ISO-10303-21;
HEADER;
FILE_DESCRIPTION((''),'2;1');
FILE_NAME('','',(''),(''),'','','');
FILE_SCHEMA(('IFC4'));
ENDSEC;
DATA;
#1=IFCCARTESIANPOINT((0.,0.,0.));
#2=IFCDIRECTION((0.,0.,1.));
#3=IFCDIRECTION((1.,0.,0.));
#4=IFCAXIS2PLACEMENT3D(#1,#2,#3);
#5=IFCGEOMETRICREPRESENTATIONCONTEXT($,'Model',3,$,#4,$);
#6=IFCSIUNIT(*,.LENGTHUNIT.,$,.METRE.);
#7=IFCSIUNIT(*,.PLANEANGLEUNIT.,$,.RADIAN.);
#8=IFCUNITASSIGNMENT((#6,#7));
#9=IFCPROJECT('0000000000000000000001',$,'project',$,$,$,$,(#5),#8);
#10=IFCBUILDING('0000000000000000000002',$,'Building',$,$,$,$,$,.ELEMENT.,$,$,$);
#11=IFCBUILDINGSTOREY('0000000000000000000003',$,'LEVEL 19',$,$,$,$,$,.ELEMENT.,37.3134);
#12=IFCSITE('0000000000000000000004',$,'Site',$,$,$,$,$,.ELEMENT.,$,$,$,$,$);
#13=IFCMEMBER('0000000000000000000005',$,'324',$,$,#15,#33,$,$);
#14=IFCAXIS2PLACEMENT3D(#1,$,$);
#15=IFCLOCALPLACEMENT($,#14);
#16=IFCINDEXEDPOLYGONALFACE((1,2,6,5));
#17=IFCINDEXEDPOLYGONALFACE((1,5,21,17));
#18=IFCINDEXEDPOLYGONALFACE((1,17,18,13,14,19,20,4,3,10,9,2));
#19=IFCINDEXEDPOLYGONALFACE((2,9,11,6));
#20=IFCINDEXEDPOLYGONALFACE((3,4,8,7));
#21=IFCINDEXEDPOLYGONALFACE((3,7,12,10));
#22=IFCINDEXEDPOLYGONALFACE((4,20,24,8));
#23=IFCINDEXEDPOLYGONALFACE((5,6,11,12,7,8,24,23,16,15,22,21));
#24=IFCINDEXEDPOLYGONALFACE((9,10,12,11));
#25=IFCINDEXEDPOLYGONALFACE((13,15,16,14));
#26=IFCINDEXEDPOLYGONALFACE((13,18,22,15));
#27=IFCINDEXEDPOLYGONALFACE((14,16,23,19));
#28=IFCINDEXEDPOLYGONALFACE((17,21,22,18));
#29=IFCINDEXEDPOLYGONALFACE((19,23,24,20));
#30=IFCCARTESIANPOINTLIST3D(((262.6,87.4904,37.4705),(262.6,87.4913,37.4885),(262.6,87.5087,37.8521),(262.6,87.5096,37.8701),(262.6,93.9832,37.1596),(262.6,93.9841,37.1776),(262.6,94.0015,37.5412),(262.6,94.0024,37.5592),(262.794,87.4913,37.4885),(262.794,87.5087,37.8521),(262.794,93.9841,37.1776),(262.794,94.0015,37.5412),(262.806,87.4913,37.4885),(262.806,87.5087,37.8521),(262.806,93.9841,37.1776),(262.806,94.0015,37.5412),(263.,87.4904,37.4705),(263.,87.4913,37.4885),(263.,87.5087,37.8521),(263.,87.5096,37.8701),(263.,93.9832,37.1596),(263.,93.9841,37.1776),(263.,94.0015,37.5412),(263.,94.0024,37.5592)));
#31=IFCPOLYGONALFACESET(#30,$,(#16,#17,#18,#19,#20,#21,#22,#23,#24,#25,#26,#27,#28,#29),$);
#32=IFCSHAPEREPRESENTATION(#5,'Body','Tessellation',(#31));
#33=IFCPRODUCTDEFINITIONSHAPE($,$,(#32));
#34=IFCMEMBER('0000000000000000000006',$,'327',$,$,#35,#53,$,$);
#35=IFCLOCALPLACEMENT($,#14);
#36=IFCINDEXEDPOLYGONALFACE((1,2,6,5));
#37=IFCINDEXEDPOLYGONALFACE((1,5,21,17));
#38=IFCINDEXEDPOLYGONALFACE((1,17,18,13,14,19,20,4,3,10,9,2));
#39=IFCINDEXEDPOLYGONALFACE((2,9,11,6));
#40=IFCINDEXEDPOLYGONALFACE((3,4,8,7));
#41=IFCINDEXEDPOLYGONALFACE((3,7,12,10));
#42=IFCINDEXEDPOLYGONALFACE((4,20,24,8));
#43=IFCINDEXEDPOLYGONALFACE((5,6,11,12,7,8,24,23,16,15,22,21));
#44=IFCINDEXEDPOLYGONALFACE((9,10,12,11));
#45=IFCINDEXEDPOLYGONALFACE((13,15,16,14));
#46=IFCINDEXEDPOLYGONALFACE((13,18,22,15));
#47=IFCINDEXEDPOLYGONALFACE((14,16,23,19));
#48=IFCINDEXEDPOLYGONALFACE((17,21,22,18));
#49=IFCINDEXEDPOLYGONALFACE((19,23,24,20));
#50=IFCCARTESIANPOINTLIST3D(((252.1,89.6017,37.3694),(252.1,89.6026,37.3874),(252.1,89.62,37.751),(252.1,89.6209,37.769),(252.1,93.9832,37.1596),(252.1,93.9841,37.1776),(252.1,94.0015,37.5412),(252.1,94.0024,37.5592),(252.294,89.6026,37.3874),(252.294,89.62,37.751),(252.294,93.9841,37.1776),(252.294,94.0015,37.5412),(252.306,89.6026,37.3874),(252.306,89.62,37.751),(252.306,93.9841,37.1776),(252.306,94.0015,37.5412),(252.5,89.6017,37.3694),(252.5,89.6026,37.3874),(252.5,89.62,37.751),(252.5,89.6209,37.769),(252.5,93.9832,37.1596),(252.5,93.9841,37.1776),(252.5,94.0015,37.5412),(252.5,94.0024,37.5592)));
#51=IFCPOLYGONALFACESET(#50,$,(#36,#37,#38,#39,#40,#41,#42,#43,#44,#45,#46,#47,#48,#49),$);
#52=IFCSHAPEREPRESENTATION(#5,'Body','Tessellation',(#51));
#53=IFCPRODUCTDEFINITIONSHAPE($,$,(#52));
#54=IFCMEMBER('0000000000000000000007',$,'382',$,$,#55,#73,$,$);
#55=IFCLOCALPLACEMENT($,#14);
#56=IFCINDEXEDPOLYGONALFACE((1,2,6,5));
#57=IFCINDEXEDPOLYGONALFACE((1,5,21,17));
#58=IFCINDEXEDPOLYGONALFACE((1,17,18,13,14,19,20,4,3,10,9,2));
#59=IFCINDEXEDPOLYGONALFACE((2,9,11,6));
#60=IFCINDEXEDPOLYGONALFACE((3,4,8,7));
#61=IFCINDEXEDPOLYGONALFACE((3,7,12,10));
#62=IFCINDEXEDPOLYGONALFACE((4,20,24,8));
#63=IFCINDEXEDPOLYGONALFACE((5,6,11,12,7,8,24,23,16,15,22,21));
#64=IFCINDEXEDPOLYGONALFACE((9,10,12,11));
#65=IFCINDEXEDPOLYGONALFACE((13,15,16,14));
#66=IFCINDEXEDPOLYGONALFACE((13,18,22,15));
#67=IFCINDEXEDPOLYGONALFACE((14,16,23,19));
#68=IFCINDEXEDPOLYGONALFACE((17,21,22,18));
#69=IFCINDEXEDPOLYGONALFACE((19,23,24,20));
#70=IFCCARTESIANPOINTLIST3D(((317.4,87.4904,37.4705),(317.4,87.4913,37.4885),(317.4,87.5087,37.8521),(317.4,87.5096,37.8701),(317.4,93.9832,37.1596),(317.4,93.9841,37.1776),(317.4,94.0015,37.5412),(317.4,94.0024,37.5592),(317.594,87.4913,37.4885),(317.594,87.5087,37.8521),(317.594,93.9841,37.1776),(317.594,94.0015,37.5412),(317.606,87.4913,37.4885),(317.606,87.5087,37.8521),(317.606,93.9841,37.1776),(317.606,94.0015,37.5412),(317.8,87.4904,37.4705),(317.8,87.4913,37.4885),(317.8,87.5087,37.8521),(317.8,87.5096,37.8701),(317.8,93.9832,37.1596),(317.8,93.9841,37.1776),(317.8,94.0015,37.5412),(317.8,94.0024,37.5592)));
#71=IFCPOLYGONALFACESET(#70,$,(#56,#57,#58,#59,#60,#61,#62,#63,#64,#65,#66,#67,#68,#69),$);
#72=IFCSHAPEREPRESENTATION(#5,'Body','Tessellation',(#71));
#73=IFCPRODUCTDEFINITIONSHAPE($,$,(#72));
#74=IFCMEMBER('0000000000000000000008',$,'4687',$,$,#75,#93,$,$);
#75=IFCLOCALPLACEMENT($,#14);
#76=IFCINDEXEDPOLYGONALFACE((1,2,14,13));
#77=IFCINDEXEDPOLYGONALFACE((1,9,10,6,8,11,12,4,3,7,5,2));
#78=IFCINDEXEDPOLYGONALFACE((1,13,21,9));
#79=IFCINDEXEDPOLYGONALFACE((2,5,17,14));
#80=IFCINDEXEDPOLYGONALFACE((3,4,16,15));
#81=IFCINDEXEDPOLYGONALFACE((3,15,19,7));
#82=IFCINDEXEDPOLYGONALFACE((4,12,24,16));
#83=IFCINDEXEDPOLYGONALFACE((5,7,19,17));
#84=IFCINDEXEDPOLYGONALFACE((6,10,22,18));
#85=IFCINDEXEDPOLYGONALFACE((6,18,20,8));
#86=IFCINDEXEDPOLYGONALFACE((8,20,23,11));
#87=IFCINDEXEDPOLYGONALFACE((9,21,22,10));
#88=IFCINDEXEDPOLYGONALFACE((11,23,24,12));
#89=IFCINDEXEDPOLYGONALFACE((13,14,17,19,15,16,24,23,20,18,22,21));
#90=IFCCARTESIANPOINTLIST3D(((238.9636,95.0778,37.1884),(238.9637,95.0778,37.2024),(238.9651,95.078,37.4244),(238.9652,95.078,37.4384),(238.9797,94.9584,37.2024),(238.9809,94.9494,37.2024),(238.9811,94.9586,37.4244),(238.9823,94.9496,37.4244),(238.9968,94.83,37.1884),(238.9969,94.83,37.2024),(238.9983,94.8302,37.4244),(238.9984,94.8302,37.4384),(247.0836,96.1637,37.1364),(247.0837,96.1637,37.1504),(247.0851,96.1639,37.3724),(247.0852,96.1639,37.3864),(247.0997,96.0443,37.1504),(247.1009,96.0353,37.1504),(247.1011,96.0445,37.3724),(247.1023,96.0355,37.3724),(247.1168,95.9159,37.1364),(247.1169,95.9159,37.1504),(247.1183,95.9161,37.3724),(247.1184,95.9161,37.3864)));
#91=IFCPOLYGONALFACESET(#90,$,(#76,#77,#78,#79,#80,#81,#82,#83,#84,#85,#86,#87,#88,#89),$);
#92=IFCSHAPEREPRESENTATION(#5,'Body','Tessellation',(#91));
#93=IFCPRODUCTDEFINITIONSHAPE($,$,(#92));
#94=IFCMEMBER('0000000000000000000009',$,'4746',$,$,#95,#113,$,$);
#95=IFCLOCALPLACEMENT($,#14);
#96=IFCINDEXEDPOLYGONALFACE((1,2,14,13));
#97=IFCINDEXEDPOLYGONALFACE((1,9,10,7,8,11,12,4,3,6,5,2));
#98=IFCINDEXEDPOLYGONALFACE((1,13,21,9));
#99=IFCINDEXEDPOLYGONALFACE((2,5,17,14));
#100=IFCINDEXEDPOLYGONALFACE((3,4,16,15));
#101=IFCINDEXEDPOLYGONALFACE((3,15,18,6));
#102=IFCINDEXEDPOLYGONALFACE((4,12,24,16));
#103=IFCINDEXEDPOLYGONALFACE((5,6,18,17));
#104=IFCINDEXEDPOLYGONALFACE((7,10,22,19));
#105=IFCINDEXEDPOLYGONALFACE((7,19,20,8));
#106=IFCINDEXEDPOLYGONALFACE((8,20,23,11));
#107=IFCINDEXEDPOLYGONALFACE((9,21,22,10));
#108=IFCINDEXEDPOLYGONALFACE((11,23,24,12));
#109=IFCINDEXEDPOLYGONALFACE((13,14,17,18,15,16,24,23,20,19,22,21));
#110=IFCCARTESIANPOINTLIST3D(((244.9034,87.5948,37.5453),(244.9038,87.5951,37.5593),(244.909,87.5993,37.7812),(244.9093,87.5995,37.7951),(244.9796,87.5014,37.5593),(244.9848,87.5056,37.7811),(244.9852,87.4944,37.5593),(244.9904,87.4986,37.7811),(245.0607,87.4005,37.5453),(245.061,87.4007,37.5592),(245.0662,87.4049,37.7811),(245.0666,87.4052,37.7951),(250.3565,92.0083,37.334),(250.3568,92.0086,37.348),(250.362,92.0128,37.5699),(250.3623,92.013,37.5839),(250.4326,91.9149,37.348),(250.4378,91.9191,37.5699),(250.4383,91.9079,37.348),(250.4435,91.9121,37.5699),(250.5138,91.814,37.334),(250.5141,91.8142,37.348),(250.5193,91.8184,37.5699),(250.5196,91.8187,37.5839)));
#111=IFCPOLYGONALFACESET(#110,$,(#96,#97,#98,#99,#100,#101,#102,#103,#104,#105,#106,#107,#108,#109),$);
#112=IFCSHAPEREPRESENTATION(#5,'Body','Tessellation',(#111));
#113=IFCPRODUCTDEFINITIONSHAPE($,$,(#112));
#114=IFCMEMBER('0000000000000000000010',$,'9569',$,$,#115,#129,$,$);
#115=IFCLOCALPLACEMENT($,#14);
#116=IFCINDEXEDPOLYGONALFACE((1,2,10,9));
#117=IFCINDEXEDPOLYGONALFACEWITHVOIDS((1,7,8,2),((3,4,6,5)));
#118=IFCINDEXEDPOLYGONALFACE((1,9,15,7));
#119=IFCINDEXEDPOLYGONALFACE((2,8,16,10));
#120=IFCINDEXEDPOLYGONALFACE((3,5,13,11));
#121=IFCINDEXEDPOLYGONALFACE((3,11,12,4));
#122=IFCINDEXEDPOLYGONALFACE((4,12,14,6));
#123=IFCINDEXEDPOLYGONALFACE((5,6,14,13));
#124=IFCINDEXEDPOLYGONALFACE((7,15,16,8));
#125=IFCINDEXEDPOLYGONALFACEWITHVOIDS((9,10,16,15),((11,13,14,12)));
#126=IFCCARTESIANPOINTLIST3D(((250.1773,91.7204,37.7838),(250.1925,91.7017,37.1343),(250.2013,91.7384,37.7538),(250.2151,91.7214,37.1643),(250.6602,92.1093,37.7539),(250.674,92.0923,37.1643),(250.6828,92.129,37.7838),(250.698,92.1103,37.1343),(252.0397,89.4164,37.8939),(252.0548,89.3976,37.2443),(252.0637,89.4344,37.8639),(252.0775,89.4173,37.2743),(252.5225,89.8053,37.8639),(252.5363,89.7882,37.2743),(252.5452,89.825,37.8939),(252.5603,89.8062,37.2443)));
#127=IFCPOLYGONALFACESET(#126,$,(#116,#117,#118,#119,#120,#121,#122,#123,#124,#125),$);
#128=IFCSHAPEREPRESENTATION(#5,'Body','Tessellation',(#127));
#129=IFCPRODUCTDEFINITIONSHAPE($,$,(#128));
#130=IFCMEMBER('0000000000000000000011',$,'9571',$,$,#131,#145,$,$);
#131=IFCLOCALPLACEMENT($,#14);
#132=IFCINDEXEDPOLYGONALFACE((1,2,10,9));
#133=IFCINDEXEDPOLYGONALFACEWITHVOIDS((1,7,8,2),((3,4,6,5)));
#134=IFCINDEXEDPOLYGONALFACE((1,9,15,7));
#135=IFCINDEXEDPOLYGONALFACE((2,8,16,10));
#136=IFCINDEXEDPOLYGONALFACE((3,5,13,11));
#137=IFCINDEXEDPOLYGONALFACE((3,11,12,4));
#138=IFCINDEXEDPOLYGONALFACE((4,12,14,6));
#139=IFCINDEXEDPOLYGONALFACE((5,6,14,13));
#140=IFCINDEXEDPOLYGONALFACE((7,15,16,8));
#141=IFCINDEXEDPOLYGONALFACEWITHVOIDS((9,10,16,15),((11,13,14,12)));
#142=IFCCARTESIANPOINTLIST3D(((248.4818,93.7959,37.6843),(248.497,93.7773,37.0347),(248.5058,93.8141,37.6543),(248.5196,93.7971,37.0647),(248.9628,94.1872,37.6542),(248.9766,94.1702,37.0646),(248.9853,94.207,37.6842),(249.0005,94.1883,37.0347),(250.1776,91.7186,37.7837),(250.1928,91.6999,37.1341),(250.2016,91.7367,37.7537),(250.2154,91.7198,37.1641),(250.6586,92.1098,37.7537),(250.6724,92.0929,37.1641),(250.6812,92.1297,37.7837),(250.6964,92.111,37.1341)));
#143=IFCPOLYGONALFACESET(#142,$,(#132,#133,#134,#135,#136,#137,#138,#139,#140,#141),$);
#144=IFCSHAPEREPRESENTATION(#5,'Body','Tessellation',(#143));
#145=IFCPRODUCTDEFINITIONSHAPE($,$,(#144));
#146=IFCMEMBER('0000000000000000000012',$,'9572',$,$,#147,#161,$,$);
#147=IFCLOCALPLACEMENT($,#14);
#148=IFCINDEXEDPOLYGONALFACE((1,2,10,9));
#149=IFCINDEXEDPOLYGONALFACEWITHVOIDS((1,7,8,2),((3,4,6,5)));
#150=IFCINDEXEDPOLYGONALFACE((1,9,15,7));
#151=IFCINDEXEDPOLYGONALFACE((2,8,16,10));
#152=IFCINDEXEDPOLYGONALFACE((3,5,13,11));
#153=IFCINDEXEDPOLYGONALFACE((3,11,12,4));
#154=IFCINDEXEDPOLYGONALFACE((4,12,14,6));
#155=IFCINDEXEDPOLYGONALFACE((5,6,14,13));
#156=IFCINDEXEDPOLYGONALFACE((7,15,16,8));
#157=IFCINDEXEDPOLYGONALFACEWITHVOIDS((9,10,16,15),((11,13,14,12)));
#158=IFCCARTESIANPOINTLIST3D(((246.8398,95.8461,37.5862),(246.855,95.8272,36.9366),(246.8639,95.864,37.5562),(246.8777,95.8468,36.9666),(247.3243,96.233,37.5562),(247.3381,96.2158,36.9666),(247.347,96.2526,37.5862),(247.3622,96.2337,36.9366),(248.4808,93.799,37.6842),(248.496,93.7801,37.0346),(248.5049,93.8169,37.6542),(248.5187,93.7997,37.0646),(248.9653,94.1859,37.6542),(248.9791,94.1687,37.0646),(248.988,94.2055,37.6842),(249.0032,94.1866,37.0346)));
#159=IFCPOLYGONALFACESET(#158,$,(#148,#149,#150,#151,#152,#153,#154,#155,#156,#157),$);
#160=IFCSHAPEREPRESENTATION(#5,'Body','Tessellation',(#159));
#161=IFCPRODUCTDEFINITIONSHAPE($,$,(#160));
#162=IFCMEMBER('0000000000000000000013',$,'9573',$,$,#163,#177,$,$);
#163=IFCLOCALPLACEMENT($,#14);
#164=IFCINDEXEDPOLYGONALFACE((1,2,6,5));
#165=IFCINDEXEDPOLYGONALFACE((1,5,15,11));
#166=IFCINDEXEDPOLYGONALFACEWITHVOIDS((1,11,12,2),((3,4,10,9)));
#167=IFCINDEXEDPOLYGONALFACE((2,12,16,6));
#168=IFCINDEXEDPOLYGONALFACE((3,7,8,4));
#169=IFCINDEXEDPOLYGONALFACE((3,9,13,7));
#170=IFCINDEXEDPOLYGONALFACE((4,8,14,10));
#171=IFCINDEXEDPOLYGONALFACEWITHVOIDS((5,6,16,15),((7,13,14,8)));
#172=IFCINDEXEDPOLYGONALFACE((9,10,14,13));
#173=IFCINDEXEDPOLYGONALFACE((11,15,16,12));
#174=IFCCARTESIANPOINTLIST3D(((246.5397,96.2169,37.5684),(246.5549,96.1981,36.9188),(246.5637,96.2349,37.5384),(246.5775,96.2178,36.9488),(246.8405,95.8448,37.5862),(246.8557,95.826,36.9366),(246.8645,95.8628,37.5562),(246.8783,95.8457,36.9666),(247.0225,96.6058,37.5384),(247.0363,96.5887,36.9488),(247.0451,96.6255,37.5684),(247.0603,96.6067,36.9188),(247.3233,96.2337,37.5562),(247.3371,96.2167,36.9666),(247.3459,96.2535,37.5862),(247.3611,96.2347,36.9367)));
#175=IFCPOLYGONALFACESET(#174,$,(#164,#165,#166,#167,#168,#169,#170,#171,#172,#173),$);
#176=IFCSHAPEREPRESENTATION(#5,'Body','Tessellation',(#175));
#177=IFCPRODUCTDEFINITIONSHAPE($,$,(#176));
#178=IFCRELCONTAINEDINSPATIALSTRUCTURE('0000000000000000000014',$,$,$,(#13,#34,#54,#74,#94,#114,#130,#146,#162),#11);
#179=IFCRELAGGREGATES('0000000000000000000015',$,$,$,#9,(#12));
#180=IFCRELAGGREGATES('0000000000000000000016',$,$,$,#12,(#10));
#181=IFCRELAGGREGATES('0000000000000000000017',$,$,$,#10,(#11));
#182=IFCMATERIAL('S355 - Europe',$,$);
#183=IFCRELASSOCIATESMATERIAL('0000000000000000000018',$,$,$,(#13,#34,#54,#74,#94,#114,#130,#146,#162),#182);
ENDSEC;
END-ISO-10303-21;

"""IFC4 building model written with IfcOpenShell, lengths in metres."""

from ifc_helpers import new_model, si_unit, frame, origin_with_axes, origin_2d_with_axis, place, context, project, spatial, hollow_rectangle, i_section, extrude, material, material_profile, profile_set, profile_usage, element, save


model = new_model("IFC4")

# Units and contexts
model_context = context("Model", 3, world=origin_with_axes())
ifc_project = project(units=[si_unit("LENGTHUNIT", "METRE"), si_unit("PLANEANGLEUNIT", "RADIAN")], contexts=[model_context])

# Site, building, storey
site = spatial("IfcSite", under=ifc_project, Name="Site", CompositionType="ELEMENT")
building = spatial("IfcBuilding", under=site, Name="Building", CompositionType="ELEMENT")
storey = spatial("IfcBuildingStorey", under=building, Name="LEVEL 19", CompositionType="ELEMENT", Elevation=37.3134)

# Shared definitions
ifc_material = material(Name="S355 - Europe")

# Members
ifc_material_profile_1 = material_profile(ifc_material, i_section(OverallWidth=0.4, OverallDepth=0.4, WebThickness=0.012, FlangeThickness=0.018, at=origin_2d_with_axis()))
ifc_profile_set_1 = profile_set([ifc_material_profile_1])
ifc_profile_usage_1 = profile_usage(ifc_profile_set_1, cardinal=10)
member_1_placement = place(None, frame((262.8, 93.9928, 37.3594), z_axis=(0.0, -0.998856, 0.047828), x_axis=(1.0, 0.0, 0.0)))
element("IfcMember", 1, at=member_1_placement, inside=storey, material=ifc_profile_usage_1, Name="324", context=model_context, shape_type="SweptSolid", body=[
    extrude(i_section(OverallWidth=0.4, OverallDepth=0.4, WebThickness=0.012, FlangeThickness=0.018, at=origin_2d_with_axis()), origin_with_axes(), (0.0, 0.0, 1.0), 6.5002),
])
ifc_material_profile_2 = material_profile(ifc_material, i_section(OverallWidth=0.4, OverallDepth=0.4, WebThickness=0.012, FlangeThickness=0.018, at=origin_2d_with_axis()))
ifc_profile_set_2 = profile_set([ifc_material_profile_2])
ifc_profile_usage_2 = profile_usage(ifc_profile_set_2, cardinal=10)
member_2_placement = place(None, frame((252.3, 93.9928, 37.3594), z_axis=(0.0, -0.998856, 0.047828), x_axis=(1.0, 0.0, 0.0)))
element("IfcMember", 2, at=member_2_placement, inside=storey, material=ifc_profile_usage_2, Name="327", context=model_context, shape_type="SweptSolid", body=[
    extrude(i_section(OverallWidth=0.4, OverallDepth=0.4, WebThickness=0.012, FlangeThickness=0.018, at=origin_2d_with_axis()), origin_with_axes(), (0.0, 0.0, 1.0), 4.3865),
])
ifc_material_profile_3 = material_profile(ifc_material, i_section(OverallWidth=0.4, OverallDepth=0.4, WebThickness=0.012, FlangeThickness=0.018, at=origin_2d_with_axis()))
ifc_profile_set_3 = profile_set([ifc_material_profile_3])
ifc_profile_usage_3 = profile_usage(ifc_profile_set_3, cardinal=10)
member_3_placement = place(None, frame((317.6, 93.9928, 37.3594), z_axis=(0.0, -0.998856, 0.047828), x_axis=(1.0, 0.0, 0.0)))
element("IfcMember", 3, at=member_3_placement, inside=storey, material=ifc_profile_usage_3, Name="382", context=model_context, shape_type="SweptSolid", body=[
    extrude(i_section(OverallWidth=0.4, OverallDepth=0.4, WebThickness=0.012, FlangeThickness=0.018, at=origin_2d_with_axis()), origin_with_axes(), (0.0, 0.0, 1.0), 6.5002),
])
ifc_material_profile_4 = material_profile(ifc_material, i_section(OverallWidth=0.25, OverallDepth=0.25, WebThickness=0.009, FlangeThickness=0.014, at=origin_2d_with_axis()))
ifc_profile_set_4 = profile_set([ifc_material_profile_4])
ifc_profile_usage_4 = profile_usage(ifc_profile_set_4, cardinal=10)
member_4_placement = place(None, frame((247.101, 96.0399, 37.2614), z_axis=(-0.991156, -0.132549, 0.006347), x_axis=(0.131592, -0.991304, 0.0)))
element("IfcMember", 4, at=member_4_placement, inside=storey, material=ifc_profile_usage_4, Name="4687", context=model_context, shape_type="SweptSolid", body=[
    extrude(i_section(OverallWidth=0.25, OverallDepth=0.25, WebThickness=0.009, FlangeThickness=0.014, at=origin_2d_with_axis()), origin_with_axes(), (0.0, 0.0, 1.0), 8.1925),
])
ifc_material_profile_5 = material_profile(ifc_material, i_section(OverallWidth=0.25, OverallDepth=0.25, WebThickness=0.009, FlangeThickness=0.014, at=origin_2d_with_axis()))
ifc_profile_set_5 = profile_set([ifc_material_profile_5])
ifc_profile_usage_5 = profile_usage(ifc_profile_set_5, cardinal=10)
member_5_placement = place(None, frame((244.985, 87.5, 37.6702), z_axis=(0.776953, 0.628839, -0.030104), x_axis=(-0.628459, 0.777842, 0.0)))
element("IfcMember", 5, at=member_5_placement, inside=storey, material=ifc_profile_usage_5, Name="4746", context=model_context, shape_type="SweptSolid", body=[
    extrude(i_section(OverallWidth=0.25, OverallDepth=0.25, WebThickness=0.009, FlangeThickness=0.014, at=origin_2d_with_axis()), origin_with_axes(), (0.0, 0.0, 1.0), 7.0185),
])
ifc_material_profile_6 = material_profile(ifc_material, hollow_rectangle(XDim=0.65, YDim=0.65, WallThickness=0.03, at=origin_2d_with_axis()))
ifc_profile_set_6 = profile_set([ifc_material_profile_6])
ifc_profile_usage_6 = profile_usage(ifc_profile_set_6, cardinal=10)
member_6_placement = place(None, frame((252.3, 89.6113, 37.5691), z_axis=(-0.628186, 0.777177, -0.03712), x_axis=(-0.77747, -0.62892, 0.0)))
element("IfcMember", 6, at=member_6_placement, inside=storey, material=ifc_profile_usage_6, Name="9569", context=model_context, shape_type="SweptSolid", body=[
    extrude(hollow_rectangle(XDim=0.65, YDim=0.65, WallThickness=0.03, at=origin_2d_with_axis()), origin_with_axes(), (0.0, 0.0, 1.0), 2.9646),
])
ifc_material_profile_7 = material_profile(ifc_material, hollow_rectangle(XDim=0.65, YDim=0.65, WallThickness=0.03, at=origin_2d_with_axis()))
ifc_profile_set_7 = profile_set([ifc_material_profile_7])
ifc_profile_usage_7 = profile_usage(ifc_profile_set_7, cardinal=10)
member_7_placement = place(None, frame((250.437, 91.9148, 37.4589), z_axis=(-0.631953, 0.774121, -0.037056), x_axis=(-0.775653, -0.63116, 0.0)))
element("IfcMember", 7, at=member_7_placement, inside=storey, material=ifc_profile_usage_7, Name="9571", context=model_context, shape_type="SweptSolid", body=[
    extrude(hollow_rectangle(XDim=0.65, YDim=0.65, WallThickness=0.03, at=origin_2d_with_axis()), origin_with_axes(), (0.0, 0.0, 1.0), 2.6835),
])
ifc_material_profile_8 = material_profile(ifc_material, hollow_rectangle(XDim=0.65, YDim=0.65, WallThickness=0.03, at=origin_2d_with_axis()))
ifc_profile_set_8 = profile_set([ifc_material_profile_8])
ifc_profile_usage_8 = profile_usage(ifc_profile_set_8, cardinal=10)
member_8_placement = place(None, frame((248.742, 93.9928, 37.3594), z_axis=(-0.62503, 0.779707, -0.037327), x_axis=(-0.780477, -0.625185, 0.0)))
element("IfcMember", 8, at=member_8_placement, inside=storey, material=ifc_profile_usage_8, Name="9572", context=model_context, shape_type="SweptSolid", body=[
    extrude(hollow_rectangle(XDim=0.65, YDim=0.65, WallThickness=0.03, at=origin_2d_with_axis()), origin_with_axes(), (0.0, 0.0, 1.0), 2.6255),
])
ifc_material_profile_9 = material_profile(ifc_material, hollow_rectangle(XDim=0.65, YDim=0.65, WallThickness=0.03, at=origin_2d_with_axis()))
ifc_profile_set_9 = profile_set([ifc_material_profile_9])
ifc_profile_usage_9 = profile_usage(ifc_profile_set_9, cardinal=10)
member_9_placement = place(None, frame((246.8, 96.4118, 37.2436), z_axis=(0.628266, -0.777107, 0.037234), x_axis=(0.777305, 0.629124, 0.0)))
element("IfcMember", 9, at=member_9_placement, inside=storey, material=ifc_profile_usage_9, Name="9573", context=model_context, shape_type="SweptSolid", body=[
    extrude(hollow_rectangle(XDim=0.65, YDim=0.65, WallThickness=0.03, at=origin_2d_with_axis()), origin_with_axes(), (0.0, 0.0, 1.0), 0.4788),
])

save(model, "model.ifc")
